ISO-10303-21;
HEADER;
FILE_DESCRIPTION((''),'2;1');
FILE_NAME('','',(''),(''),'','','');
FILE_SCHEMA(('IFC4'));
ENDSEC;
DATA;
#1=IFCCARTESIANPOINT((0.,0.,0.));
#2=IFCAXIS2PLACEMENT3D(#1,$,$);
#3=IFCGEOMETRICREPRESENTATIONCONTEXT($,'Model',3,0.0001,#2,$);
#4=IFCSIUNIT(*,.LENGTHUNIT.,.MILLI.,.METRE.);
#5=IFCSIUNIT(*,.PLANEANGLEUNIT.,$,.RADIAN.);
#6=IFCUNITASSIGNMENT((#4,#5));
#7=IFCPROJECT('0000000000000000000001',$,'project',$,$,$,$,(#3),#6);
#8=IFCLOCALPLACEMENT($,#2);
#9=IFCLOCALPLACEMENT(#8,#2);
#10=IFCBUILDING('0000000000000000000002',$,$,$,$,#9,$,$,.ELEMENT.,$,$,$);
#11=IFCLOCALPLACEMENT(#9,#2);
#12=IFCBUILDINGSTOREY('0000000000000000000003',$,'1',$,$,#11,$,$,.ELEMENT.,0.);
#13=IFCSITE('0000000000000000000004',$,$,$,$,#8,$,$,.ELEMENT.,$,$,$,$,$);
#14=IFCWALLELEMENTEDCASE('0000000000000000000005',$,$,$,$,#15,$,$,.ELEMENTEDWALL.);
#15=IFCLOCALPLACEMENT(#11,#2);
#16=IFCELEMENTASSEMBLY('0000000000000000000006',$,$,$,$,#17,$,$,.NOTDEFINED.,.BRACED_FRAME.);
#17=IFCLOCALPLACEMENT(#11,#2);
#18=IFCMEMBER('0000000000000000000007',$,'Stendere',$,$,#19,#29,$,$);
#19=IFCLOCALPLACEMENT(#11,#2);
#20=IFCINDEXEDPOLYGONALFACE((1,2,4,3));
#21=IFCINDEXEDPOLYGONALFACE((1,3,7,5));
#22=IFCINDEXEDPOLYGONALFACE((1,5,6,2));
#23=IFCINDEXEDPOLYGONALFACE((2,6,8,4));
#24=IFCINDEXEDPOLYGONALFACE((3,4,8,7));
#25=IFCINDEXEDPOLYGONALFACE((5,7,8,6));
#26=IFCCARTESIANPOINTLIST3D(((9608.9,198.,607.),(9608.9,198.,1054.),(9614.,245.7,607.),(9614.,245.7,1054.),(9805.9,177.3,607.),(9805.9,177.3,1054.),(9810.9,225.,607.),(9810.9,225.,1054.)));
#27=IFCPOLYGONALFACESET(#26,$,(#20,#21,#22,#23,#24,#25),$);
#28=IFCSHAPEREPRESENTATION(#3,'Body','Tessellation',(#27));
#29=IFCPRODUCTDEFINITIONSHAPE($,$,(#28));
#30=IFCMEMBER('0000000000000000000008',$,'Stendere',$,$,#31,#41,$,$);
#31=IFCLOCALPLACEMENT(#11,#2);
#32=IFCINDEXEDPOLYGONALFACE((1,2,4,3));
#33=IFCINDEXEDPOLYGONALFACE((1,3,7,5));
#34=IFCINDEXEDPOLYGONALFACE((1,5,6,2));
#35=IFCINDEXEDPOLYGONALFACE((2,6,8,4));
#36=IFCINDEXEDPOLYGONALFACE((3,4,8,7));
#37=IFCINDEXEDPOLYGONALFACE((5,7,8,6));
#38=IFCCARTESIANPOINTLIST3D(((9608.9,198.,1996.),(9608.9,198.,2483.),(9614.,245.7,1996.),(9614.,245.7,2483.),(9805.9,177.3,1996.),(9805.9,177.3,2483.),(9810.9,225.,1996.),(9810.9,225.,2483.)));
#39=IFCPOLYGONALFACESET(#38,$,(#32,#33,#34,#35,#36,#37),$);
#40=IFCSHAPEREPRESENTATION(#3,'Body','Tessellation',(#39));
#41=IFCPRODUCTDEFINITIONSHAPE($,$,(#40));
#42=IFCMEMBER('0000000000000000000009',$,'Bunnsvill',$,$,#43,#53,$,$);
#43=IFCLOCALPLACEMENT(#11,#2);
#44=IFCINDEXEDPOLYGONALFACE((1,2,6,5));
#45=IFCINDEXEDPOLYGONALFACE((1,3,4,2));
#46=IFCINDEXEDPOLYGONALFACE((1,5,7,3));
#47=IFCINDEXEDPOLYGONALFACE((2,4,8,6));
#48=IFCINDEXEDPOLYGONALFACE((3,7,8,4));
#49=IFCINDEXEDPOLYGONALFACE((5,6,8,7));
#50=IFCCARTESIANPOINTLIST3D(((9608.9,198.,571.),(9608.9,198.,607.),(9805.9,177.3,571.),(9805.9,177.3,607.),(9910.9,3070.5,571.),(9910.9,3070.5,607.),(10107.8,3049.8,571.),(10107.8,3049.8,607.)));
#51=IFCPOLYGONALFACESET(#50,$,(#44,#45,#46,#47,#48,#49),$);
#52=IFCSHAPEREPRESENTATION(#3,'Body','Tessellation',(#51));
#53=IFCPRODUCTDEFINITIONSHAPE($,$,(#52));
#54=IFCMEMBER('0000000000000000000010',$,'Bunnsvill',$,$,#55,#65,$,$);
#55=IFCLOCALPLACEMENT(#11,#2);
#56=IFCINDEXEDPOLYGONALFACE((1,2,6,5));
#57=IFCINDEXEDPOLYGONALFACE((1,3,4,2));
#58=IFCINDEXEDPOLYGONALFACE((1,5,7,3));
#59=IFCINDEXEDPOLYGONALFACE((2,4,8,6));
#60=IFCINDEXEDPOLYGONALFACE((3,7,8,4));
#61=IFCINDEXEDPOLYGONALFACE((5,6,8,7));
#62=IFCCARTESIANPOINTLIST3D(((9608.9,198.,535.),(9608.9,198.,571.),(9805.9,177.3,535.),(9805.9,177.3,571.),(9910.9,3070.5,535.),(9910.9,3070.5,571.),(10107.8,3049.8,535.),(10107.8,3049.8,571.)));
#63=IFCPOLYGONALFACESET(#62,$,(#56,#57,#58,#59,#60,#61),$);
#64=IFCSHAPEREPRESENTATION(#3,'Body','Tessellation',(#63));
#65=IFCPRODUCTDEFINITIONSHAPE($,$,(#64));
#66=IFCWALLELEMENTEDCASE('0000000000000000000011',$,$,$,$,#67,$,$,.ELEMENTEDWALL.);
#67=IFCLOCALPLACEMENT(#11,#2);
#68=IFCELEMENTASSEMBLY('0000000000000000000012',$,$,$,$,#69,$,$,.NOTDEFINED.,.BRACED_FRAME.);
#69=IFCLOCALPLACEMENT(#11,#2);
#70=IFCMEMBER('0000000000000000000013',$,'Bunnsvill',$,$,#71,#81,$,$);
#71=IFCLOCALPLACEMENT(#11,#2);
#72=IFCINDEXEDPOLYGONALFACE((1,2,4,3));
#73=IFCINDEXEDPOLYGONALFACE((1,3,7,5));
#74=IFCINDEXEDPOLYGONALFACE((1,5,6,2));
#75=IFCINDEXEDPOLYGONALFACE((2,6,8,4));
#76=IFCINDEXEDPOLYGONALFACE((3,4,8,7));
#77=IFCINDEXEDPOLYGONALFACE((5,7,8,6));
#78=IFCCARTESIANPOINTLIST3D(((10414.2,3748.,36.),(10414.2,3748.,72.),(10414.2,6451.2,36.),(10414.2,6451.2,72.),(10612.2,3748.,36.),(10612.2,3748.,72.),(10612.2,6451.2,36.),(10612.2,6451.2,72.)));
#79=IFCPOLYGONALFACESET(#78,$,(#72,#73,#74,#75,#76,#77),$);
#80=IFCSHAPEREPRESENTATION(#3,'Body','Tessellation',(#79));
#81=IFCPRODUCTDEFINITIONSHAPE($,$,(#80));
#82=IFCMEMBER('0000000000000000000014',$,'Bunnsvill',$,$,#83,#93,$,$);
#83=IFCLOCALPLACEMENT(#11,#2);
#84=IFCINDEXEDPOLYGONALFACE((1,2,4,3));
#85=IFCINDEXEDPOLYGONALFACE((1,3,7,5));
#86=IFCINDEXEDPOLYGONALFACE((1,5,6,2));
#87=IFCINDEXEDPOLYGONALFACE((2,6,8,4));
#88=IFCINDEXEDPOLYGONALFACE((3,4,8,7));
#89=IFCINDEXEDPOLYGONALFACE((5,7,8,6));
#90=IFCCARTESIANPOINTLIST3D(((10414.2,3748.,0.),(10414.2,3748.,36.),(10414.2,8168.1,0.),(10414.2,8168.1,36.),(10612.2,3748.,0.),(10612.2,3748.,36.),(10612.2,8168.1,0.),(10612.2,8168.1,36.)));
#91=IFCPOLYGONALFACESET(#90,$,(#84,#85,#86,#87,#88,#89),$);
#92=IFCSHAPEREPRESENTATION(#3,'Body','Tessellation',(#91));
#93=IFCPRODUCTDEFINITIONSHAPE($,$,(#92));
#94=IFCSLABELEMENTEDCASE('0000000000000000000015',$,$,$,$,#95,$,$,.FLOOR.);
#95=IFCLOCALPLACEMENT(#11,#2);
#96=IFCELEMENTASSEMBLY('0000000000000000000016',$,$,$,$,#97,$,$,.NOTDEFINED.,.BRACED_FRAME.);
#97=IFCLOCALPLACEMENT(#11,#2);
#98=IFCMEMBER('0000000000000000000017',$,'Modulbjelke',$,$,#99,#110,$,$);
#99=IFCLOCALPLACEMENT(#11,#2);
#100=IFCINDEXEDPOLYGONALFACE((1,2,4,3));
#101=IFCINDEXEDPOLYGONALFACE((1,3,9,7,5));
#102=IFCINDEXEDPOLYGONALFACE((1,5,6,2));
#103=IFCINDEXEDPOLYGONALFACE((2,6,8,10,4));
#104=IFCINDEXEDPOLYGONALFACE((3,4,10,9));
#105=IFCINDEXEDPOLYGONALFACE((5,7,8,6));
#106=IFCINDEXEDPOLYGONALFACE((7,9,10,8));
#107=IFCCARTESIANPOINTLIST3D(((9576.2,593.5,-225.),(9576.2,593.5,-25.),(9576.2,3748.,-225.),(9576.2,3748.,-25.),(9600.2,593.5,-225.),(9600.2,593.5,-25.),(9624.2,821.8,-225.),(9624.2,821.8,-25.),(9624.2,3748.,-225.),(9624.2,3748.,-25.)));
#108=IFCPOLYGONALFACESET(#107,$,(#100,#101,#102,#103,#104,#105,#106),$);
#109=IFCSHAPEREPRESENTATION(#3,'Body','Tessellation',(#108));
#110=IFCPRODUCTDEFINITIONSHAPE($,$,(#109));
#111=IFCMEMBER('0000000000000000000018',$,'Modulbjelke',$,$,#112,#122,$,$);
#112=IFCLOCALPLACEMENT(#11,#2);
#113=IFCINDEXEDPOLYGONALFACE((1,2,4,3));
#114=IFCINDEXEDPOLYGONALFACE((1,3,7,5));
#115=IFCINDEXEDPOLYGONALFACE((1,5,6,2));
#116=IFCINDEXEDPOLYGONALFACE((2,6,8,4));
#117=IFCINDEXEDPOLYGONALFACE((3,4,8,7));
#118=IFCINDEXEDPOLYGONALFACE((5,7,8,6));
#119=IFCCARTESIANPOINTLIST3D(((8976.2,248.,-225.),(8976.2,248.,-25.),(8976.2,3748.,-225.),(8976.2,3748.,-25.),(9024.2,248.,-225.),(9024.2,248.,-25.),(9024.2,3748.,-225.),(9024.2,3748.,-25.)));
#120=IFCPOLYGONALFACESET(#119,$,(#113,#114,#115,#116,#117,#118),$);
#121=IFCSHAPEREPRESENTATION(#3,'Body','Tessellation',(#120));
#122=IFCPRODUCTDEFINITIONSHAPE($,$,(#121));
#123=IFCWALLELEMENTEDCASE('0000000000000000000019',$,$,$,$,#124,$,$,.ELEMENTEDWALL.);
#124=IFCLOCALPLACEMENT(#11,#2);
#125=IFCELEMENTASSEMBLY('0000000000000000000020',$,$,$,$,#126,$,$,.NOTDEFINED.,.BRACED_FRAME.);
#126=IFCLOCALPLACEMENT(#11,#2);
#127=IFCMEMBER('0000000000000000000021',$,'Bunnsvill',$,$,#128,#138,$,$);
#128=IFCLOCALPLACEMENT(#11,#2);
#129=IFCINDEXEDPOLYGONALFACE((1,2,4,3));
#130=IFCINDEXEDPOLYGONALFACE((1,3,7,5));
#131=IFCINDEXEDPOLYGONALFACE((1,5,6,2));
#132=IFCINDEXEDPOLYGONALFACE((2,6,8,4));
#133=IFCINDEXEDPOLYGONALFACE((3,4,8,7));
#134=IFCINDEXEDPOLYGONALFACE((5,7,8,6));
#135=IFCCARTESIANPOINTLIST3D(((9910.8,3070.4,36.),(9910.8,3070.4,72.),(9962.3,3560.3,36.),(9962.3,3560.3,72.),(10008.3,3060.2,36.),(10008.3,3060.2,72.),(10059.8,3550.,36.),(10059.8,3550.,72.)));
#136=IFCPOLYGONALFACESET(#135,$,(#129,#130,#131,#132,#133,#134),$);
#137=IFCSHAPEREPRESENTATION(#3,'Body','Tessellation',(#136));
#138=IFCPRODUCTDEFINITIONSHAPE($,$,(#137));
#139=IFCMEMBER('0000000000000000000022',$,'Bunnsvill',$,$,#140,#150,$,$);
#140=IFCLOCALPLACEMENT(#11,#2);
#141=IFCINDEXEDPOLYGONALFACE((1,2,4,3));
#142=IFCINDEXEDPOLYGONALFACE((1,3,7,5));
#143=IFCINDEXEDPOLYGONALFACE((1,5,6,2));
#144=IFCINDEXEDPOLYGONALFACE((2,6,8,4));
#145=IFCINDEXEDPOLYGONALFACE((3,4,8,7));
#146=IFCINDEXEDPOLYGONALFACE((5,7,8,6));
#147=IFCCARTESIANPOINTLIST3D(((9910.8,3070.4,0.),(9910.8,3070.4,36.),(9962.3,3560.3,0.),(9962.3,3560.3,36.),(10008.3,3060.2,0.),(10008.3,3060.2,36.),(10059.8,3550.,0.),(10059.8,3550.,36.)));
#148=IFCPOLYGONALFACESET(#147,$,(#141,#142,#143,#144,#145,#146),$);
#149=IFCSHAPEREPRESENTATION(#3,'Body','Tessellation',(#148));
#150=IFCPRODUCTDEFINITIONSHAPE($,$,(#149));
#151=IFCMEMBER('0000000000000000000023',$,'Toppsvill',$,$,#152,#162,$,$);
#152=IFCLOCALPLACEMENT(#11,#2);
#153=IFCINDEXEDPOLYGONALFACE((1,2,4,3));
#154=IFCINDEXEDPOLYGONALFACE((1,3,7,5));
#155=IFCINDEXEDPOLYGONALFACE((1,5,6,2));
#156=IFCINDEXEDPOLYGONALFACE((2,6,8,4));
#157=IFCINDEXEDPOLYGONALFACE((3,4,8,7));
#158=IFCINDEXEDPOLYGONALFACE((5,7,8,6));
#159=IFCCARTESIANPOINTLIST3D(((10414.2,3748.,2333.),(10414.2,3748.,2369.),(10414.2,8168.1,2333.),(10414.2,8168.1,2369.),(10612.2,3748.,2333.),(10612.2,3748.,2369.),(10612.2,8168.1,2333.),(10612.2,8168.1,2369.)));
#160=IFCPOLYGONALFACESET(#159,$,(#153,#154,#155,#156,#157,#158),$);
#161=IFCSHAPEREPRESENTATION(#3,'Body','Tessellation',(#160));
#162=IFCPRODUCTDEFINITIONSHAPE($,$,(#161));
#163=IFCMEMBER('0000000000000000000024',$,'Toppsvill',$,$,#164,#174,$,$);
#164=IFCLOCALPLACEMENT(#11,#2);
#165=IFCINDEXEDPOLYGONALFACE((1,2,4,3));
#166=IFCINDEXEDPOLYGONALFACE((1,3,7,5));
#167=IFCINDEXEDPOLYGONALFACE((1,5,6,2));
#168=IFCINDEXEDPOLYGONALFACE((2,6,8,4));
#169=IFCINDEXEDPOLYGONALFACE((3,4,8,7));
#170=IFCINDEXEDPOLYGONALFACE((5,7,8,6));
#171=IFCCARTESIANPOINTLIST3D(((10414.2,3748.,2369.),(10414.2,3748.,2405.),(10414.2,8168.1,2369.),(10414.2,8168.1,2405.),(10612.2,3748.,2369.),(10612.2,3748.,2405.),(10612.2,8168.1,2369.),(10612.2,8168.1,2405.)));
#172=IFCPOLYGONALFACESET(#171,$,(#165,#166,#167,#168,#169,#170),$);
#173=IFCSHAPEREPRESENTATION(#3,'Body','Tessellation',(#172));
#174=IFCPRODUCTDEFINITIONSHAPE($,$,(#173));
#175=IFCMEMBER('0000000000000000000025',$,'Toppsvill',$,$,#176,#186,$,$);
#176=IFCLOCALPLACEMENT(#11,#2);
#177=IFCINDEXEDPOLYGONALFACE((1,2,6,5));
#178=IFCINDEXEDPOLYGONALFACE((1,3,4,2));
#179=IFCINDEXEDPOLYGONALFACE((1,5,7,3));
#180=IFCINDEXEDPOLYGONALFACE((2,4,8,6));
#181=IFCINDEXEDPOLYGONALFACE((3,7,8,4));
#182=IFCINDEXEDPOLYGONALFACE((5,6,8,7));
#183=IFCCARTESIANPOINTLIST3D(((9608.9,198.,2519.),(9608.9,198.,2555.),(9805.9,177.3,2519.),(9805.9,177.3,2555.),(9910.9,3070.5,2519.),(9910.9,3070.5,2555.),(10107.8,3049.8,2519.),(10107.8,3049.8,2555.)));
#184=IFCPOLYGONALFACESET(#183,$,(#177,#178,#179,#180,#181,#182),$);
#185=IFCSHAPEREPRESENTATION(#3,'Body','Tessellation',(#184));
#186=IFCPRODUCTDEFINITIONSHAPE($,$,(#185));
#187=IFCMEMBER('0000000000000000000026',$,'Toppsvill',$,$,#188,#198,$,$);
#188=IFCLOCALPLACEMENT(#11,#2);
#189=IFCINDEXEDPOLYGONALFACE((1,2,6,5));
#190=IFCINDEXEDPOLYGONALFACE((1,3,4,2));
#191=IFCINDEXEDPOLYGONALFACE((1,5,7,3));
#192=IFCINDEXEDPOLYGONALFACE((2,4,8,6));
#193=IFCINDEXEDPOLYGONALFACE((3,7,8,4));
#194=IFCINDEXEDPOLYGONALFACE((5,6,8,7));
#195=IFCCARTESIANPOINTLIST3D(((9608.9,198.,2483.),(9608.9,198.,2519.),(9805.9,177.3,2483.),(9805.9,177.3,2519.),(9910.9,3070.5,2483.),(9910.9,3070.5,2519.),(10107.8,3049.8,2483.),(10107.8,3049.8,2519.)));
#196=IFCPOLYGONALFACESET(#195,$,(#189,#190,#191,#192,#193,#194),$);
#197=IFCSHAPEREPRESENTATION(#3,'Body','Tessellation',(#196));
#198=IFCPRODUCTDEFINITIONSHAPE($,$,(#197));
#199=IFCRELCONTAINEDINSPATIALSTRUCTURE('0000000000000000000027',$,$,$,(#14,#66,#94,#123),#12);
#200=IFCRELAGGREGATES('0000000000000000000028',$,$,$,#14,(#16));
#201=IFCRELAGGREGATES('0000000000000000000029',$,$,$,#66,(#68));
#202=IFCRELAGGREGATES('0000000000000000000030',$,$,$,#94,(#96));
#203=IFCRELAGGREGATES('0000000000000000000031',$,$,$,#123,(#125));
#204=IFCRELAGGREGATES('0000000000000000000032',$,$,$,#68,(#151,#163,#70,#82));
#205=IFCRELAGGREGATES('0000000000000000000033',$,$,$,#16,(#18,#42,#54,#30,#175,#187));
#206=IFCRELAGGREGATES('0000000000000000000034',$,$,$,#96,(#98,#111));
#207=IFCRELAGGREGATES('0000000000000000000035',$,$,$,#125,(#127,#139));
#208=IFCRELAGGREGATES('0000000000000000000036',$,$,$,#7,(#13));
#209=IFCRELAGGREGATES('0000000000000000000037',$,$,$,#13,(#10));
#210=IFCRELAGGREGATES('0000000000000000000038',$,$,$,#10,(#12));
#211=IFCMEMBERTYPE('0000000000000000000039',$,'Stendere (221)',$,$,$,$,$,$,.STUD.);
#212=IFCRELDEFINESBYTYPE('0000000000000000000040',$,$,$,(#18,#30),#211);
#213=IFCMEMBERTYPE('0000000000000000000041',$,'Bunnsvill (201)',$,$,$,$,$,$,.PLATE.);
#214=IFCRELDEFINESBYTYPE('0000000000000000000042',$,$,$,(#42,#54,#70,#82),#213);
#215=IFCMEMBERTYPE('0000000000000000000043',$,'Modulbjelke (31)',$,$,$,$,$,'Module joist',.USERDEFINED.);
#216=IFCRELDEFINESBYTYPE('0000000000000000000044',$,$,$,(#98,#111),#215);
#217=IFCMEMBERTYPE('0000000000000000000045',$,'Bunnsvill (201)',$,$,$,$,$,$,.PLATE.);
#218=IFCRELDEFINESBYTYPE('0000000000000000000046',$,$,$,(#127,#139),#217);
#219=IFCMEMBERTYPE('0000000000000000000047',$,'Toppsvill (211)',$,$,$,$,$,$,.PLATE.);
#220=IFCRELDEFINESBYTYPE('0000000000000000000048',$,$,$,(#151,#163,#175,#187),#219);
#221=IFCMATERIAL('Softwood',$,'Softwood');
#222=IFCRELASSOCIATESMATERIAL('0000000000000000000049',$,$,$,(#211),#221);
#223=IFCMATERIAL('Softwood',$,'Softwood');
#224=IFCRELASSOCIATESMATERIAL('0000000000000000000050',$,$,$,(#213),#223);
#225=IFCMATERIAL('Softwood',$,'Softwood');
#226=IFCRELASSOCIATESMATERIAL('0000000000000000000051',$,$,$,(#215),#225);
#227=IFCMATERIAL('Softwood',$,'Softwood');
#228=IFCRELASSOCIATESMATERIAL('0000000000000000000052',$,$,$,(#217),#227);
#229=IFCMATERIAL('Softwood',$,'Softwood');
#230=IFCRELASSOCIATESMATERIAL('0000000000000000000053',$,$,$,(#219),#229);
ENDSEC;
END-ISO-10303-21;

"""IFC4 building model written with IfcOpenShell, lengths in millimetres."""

from ifc_helpers import new_model, si_unit, frame, origin, place, context, project, spatial, rectangle, extrude, clip, halfspace, material, material_profile, profile_set, type_object, element, aggregate, save


model = new_model("IFC4")

# Units and contexts
model_context = context("Model", 3, precision=0.0001, world=origin())
ifc_project = project(units=[si_unit("LENGTHUNIT", "METRE", prefix="MILLI"), si_unit("PLANEANGLEUNIT", "RADIAN")], contexts=[model_context])

# Site, building, storey
site_placement = place(None, origin())
site = spatial("IfcSite", under=ifc_project, at=site_placement, CompositionType="ELEMENT")
building_placement = place(site_placement, origin())
building = spatial("IfcBuilding", under=site, at=building_placement, CompositionType="ELEMENT")
storey_placement = place(building_placement, origin())
storey = spatial("IfcBuildingStorey", under=building, at=storey_placement, Name="1", CompositionType="ELEMENT", Elevation=0.0)

# Walls, element assemblies, members
wall_1_placement = place(storey_placement, frame((9608.9, 198.0, 535.0), z_axis=(0.994522, -0.104529, 0.0), x_axis=(0.104529, 0.994522, 0.0)))
wall_1 = element("IfcWallElementedCase", 1, at=wall_1_placement, inside=storey, PredefinedType="ELEMENTEDWALL")
assembly_1_placement = place(wall_1_placement, origin())
assembly_1 = element("IfcElementAssembly", 2, at=assembly_1_placement, AssemblyPlace="NOTDEFINED", PredefinedType="BRACED_FRAME")
aggregate(wall_1, [assembly_1])
ifc_material_1 = material(Name="Softwood", Category="Softwood")
ifc_material_profile_1 = material_profile(ifc_material_1, rectangle(XDim=48.0, YDim=198.0), Name="Stendere (221)")
ifc_profile_set_1 = profile_set([ifc_material_profile_1])
member_type_1 = type_object("IfcMemberType", Name="Stendere (221)", PredefinedType="STUD", material=ifc_profile_set_1)
member_1_placement = place(assembly_1_placement, frame((24.0, 72.0, 0.0), z_axis=(0.0, 1.0, 0.0), x_axis=(-1.0, 0.0, 0.0)))
member_1 = element("IfcMember", 3, at=member_1_placement, type_object=member_type_1, Name="Stendere", context=model_context, shape_type="SweptSolid", body=[
    extrude(rectangle(XDim=48.0, YDim=198.0), frame((0.0, 99.0, 0.0)), (0.0, 0.0, 1.0), 447.0),
])
member_2_placement = place(assembly_1_placement, frame((24.0, 1461.0, 0.0), z_axis=(0.0, 1.0, 0.0), x_axis=(-1.0, 0.0, 0.0)))
member_2 = element("IfcMember", 4, at=member_2_placement, type_object=member_type_1, Name="Stendere", context=model_context, shape_type="SweptSolid", body=[
    extrude(rectangle(XDim=48.0, YDim=198.0), frame((0.0, 99.0, 0.0)), (0.0, 0.0, 1.0), 487.0),
])
ifc_material_2 = material(Name="Softwood", Category="Softwood")
ifc_material_profile_2 = material_profile(ifc_material_2, rectangle(XDim=36.0, YDim=198.0), Name="Bunnsvill (201)")
ifc_profile_set_2 = profile_set([ifc_material_profile_2])
member_type_2 = type_object("IfcMemberType", Name="Bunnsvill (201)", PredefinedType="PLATE", material=ifc_profile_set_2)
member_3_placement = place(assembly_1_placement, frame((0.0, 54.0, 0.0), z_axis=(1.0, 0.0, 0.0), x_axis=(0.0, 1.0, 0.0)))
member_3 = element("IfcMember", 5, at=member_3_placement, type_object=member_type_2, Name="Bunnsvill", context=model_context, shape_type="SweptSolid", body=[
    extrude(rectangle(XDim=36.0, YDim=198.0), frame((0.0, 99.0, 0.0)), (0.0, 0.0, 1.0), 2888.3),
])
member_4_placement = place(assembly_1_placement, frame((0.0, 18.0, 0.0), z_axis=(1.0, 0.0, 0.0), x_axis=(0.0, 1.0, 0.0)))
member_4 = element("IfcMember", 6, at=member_4_placement, type_object=member_type_2, Name="Bunnsvill", context=model_context, shape_type="SweptSolid", body=[
    extrude(rectangle(XDim=36.0, YDim=198.0), frame((0.0, 99.0, 0.0)), (0.0, 0.0, 1.0), 2888.3),
])
wall_2_placement = place(storey_placement, frame((10414.2, 3748.0, 0.0), z_axis=(1.0, 0.0, 0.0), x_axis=(0.0, 1.0, 0.0)))
wall_2 = element("IfcWallElementedCase", 7, at=wall_2_placement, inside=storey, PredefinedType="ELEMENTEDWALL")
assembly_2_placement = place(wall_2_placement, origin())
assembly_2 = element("IfcElementAssembly", 8, at=assembly_2_placement, AssemblyPlace="NOTDEFINED", PredefinedType="BRACED_FRAME")
aggregate(wall_2, [assembly_2])
member_5_placement = place(assembly_2_placement, frame((0.0, 54.0, 0.0), z_axis=(1.0, 0.0, 0.0), x_axis=(0.0, 1.0, 0.0)))
member_5 = element("IfcMember", 9, at=member_5_placement, type_object=member_type_2, Name="Bunnsvill", context=model_context, shape_type="SweptSolid", body=[
    extrude(rectangle(XDim=36.0, YDim=198.0), frame((0.0, 99.0, 0.0)), (0.0, 0.0, 1.0), 2703.2),
])
member_6_placement = place(assembly_2_placement, frame((0.0, 18.0, 0.0), z_axis=(1.0, 0.0, 0.0), x_axis=(0.0, 1.0, 0.0)))
member_6 = element("IfcMember", 10, at=member_6_placement, type_object=member_type_2, Name="Bunnsvill", context=model_context, shape_type="SweptSolid", body=[
    extrude(rectangle(XDim=36.0, YDim=198.0), frame((0.0, 99.0, 0.0)), (0.0, 0.0, 1.0), 4420.1),
])

# Slab, element assembly, members
slab_placement = place(storey_placement, origin())
slab = element("IfcSlabElementedCase", 11, at=slab_placement, inside=storey, PredefinedType="FLOOR")
assembly_3_placement = place(slab_placement, frame((0.0, 0.0, -225.0)))
assembly_3 = element("IfcElementAssembly", 12, at=assembly_3_placement, AssemblyPlace="NOTDEFINED", PredefinedType="BRACED_FRAME")
aggregate(slab, [assembly_3])
ifc_material_3 = material(Name="Softwood", Category="Softwood")
ifc_material_profile_3 = material_profile(ifc_material_3, rectangle(XDim=48.0, YDim=200.0), Name="Modulbjelke (31)")
ifc_profile_set_3 = profile_set([ifc_material_profile_3])
member_type_3 = type_object("IfcMemberType", Name="Modulbjelke (31)", ElementType="Module joist", PredefinedType="USERDEFINED", material=ifc_profile_set_3)
member_7_placement = place(assembly_3_placement, frame((9600.2, 593.5, 0.0), z_axis=(0.0, 1.0, 0.0), x_axis=(-1.0, 0.0, 0.0)))
member_7 = element("IfcMember", 13, at=member_7_placement, type_object=member_type_3, Name="Modulbjelke", context=model_context, shape_type="Clipping", body=[
    clip(extrude(rectangle(XDim=48.0, YDim=200.0), frame((0.0, 100.0, 0.0)), (0.0, 0.0, 1.0), 3154.5), halfspace(frame((0.0, 100.0, 0.0), z_axis=(0.994519, 0.0, 0.104554), x_axis=(0.104554, 0.0, -0.994519)), True)),
])
member_8_placement = place(assembly_3_placement, frame((9000.2, 248.0, 0.0), z_axis=(0.0, 1.0, 0.0), x_axis=(-1.0, 0.0, 0.0)))
member_8 = element("IfcMember", 14, at=member_8_placement, type_object=member_type_3, Name="Modulbjelke", context=model_context, shape_type="SweptSolid", body=[
    extrude(rectangle(XDim=48.0, YDim=200.0), frame((0.0, 100.0, 0.0)), (0.0, 0.0, 1.0), 3500.0),
])

# Wall, element assembly, members
wall_3_placement = place(storey_placement, frame((9910.8, 3070.4, 0.0), z_axis=(0.994522, -0.104529, 0.0), x_axis=(0.104529, 0.994522, 0.0)))
wall_3 = element("IfcWallElementedCase", 15, at=wall_3_placement, inside=storey, PredefinedType="ELEMENTEDWALL")
assembly_4_placement = place(wall_3_placement, origin())
assembly_4 = element("IfcElementAssembly", 16, at=assembly_4_placement, AssemblyPlace="NOTDEFINED", PredefinedType="BRACED_FRAME")
aggregate(wall_3, [assembly_4])
ifc_material_4 = material(Name="Softwood", Category="Softwood")
ifc_material_profile_4 = material_profile(ifc_material_4, rectangle(XDim=36.0, YDim=98.0), Name="Bunnsvill (201)")
ifc_profile_set_4 = profile_set([ifc_material_profile_4])
member_type_4 = type_object("IfcMemberType", Name="Bunnsvill (201)", PredefinedType="PLATE", material=ifc_profile_set_4)
member_9_placement = place(assembly_4_placement, frame((0.0, 54.0, 0.0), z_axis=(1.0, 0.0, 0.0), x_axis=(0.0, 1.0, 0.0)))
member_9 = element("IfcMember", 17, at=member_9_placement, type_object=member_type_4, Name="Bunnsvill", context=model_context, shape_type="SweptSolid", body=[
    extrude(rectangle(XDim=36.0, YDim=98.0), frame((0.0, 49.0, 0.0)), (0.0, 0.0, 1.0), 492.5),
])
member_10_placement = place(assembly_4_placement, frame((0.0, 18.0, 0.0), z_axis=(1.0, 0.0, 0.0), x_axis=(0.0, 1.0, 0.0)))
member_10 = element("IfcMember", 18, at=member_10_placement, type_object=member_type_4, Name="Bunnsvill", context=model_context, shape_type="SweptSolid", body=[
    extrude(rectangle(XDim=36.0, YDim=98.0), frame((0.0, 49.0, 0.0)), (0.0, 0.0, 1.0), 492.5),
])

# Members
ifc_material_5 = material(Name="Softwood", Category="Softwood")
ifc_material_profile_5 = material_profile(ifc_material_5, rectangle(XDim=36.0, YDim=198.0), Name="Toppsvill (211)")
ifc_profile_set_5 = profile_set([ifc_material_profile_5])
member_type_5 = type_object("IfcMemberType", Name="Toppsvill (211)", PredefinedType="PLATE", material=ifc_profile_set_5)
member_11_placement = place(assembly_2_placement, frame((0.0, 2351.0, 0.0), z_axis=(1.0, 0.0, 0.0), x_axis=(0.0, 1.0, 0.0)))
member_11 = element("IfcMember", 19, at=member_11_placement, type_object=member_type_5, Name="Toppsvill", context=model_context, shape_type="SweptSolid", body=[
    extrude(rectangle(XDim=36.0, YDim=198.0), frame((0.0, 99.0, 0.0)), (0.0, 0.0, 1.0), 4420.1),
])
member_12_placement = place(assembly_2_placement, frame((0.0, 2387.0, 0.0), z_axis=(1.0, 0.0, 0.0), x_axis=(0.0, 1.0, 0.0)))
member_12 = element("IfcMember", 20, at=member_12_placement, type_object=member_type_5, Name="Toppsvill", context=model_context, shape_type="SweptSolid", body=[
    extrude(rectangle(XDim=36.0, YDim=198.0), frame((0.0, 99.0, 0.0)), (0.0, 0.0, 1.0), 4420.1),
])
aggregate(assembly_2, [member_11, member_12, member_5, member_6])
member_13_placement = place(assembly_1_placement, frame((0.0, 2002.0, 0.0), z_axis=(1.0, 0.0, 0.0), x_axis=(0.0, 1.0, 0.0)))
member_13 = element("IfcMember", 21, at=member_13_placement, type_object=member_type_5, Name="Toppsvill", context=model_context, shape_type="SweptSolid", body=[
    extrude(rectangle(XDim=36.0, YDim=198.0), frame((0.0, 99.0, 0.0)), (0.0, 0.0, 1.0), 2888.3),
])
member_14_placement = place(assembly_1_placement, frame((0.0, 1966.0, 0.0), z_axis=(1.0, 0.0, 0.0), x_axis=(0.0, 1.0, 0.0)))
member_14 = element("IfcMember", 22, at=member_14_placement, type_object=member_type_5, Name="Toppsvill", context=model_context, shape_type="Clipping", body=[
    clip(extrude(rectangle(XDim=36.0, YDim=198.0), frame((0.0, 99.0, 0.0)), (0.0, 0.0, 1.0), 2888.3), halfspace(frame((0.0, 99.0, 0.0)), True)),
])
aggregate(assembly_1, [member_1, member_3, member_4, member_2, member_13, member_14])

aggregate(assembly_3, [member_7, member_8])
aggregate(assembly_4, [member_9, member_10])

save(model, "model.ifc")
